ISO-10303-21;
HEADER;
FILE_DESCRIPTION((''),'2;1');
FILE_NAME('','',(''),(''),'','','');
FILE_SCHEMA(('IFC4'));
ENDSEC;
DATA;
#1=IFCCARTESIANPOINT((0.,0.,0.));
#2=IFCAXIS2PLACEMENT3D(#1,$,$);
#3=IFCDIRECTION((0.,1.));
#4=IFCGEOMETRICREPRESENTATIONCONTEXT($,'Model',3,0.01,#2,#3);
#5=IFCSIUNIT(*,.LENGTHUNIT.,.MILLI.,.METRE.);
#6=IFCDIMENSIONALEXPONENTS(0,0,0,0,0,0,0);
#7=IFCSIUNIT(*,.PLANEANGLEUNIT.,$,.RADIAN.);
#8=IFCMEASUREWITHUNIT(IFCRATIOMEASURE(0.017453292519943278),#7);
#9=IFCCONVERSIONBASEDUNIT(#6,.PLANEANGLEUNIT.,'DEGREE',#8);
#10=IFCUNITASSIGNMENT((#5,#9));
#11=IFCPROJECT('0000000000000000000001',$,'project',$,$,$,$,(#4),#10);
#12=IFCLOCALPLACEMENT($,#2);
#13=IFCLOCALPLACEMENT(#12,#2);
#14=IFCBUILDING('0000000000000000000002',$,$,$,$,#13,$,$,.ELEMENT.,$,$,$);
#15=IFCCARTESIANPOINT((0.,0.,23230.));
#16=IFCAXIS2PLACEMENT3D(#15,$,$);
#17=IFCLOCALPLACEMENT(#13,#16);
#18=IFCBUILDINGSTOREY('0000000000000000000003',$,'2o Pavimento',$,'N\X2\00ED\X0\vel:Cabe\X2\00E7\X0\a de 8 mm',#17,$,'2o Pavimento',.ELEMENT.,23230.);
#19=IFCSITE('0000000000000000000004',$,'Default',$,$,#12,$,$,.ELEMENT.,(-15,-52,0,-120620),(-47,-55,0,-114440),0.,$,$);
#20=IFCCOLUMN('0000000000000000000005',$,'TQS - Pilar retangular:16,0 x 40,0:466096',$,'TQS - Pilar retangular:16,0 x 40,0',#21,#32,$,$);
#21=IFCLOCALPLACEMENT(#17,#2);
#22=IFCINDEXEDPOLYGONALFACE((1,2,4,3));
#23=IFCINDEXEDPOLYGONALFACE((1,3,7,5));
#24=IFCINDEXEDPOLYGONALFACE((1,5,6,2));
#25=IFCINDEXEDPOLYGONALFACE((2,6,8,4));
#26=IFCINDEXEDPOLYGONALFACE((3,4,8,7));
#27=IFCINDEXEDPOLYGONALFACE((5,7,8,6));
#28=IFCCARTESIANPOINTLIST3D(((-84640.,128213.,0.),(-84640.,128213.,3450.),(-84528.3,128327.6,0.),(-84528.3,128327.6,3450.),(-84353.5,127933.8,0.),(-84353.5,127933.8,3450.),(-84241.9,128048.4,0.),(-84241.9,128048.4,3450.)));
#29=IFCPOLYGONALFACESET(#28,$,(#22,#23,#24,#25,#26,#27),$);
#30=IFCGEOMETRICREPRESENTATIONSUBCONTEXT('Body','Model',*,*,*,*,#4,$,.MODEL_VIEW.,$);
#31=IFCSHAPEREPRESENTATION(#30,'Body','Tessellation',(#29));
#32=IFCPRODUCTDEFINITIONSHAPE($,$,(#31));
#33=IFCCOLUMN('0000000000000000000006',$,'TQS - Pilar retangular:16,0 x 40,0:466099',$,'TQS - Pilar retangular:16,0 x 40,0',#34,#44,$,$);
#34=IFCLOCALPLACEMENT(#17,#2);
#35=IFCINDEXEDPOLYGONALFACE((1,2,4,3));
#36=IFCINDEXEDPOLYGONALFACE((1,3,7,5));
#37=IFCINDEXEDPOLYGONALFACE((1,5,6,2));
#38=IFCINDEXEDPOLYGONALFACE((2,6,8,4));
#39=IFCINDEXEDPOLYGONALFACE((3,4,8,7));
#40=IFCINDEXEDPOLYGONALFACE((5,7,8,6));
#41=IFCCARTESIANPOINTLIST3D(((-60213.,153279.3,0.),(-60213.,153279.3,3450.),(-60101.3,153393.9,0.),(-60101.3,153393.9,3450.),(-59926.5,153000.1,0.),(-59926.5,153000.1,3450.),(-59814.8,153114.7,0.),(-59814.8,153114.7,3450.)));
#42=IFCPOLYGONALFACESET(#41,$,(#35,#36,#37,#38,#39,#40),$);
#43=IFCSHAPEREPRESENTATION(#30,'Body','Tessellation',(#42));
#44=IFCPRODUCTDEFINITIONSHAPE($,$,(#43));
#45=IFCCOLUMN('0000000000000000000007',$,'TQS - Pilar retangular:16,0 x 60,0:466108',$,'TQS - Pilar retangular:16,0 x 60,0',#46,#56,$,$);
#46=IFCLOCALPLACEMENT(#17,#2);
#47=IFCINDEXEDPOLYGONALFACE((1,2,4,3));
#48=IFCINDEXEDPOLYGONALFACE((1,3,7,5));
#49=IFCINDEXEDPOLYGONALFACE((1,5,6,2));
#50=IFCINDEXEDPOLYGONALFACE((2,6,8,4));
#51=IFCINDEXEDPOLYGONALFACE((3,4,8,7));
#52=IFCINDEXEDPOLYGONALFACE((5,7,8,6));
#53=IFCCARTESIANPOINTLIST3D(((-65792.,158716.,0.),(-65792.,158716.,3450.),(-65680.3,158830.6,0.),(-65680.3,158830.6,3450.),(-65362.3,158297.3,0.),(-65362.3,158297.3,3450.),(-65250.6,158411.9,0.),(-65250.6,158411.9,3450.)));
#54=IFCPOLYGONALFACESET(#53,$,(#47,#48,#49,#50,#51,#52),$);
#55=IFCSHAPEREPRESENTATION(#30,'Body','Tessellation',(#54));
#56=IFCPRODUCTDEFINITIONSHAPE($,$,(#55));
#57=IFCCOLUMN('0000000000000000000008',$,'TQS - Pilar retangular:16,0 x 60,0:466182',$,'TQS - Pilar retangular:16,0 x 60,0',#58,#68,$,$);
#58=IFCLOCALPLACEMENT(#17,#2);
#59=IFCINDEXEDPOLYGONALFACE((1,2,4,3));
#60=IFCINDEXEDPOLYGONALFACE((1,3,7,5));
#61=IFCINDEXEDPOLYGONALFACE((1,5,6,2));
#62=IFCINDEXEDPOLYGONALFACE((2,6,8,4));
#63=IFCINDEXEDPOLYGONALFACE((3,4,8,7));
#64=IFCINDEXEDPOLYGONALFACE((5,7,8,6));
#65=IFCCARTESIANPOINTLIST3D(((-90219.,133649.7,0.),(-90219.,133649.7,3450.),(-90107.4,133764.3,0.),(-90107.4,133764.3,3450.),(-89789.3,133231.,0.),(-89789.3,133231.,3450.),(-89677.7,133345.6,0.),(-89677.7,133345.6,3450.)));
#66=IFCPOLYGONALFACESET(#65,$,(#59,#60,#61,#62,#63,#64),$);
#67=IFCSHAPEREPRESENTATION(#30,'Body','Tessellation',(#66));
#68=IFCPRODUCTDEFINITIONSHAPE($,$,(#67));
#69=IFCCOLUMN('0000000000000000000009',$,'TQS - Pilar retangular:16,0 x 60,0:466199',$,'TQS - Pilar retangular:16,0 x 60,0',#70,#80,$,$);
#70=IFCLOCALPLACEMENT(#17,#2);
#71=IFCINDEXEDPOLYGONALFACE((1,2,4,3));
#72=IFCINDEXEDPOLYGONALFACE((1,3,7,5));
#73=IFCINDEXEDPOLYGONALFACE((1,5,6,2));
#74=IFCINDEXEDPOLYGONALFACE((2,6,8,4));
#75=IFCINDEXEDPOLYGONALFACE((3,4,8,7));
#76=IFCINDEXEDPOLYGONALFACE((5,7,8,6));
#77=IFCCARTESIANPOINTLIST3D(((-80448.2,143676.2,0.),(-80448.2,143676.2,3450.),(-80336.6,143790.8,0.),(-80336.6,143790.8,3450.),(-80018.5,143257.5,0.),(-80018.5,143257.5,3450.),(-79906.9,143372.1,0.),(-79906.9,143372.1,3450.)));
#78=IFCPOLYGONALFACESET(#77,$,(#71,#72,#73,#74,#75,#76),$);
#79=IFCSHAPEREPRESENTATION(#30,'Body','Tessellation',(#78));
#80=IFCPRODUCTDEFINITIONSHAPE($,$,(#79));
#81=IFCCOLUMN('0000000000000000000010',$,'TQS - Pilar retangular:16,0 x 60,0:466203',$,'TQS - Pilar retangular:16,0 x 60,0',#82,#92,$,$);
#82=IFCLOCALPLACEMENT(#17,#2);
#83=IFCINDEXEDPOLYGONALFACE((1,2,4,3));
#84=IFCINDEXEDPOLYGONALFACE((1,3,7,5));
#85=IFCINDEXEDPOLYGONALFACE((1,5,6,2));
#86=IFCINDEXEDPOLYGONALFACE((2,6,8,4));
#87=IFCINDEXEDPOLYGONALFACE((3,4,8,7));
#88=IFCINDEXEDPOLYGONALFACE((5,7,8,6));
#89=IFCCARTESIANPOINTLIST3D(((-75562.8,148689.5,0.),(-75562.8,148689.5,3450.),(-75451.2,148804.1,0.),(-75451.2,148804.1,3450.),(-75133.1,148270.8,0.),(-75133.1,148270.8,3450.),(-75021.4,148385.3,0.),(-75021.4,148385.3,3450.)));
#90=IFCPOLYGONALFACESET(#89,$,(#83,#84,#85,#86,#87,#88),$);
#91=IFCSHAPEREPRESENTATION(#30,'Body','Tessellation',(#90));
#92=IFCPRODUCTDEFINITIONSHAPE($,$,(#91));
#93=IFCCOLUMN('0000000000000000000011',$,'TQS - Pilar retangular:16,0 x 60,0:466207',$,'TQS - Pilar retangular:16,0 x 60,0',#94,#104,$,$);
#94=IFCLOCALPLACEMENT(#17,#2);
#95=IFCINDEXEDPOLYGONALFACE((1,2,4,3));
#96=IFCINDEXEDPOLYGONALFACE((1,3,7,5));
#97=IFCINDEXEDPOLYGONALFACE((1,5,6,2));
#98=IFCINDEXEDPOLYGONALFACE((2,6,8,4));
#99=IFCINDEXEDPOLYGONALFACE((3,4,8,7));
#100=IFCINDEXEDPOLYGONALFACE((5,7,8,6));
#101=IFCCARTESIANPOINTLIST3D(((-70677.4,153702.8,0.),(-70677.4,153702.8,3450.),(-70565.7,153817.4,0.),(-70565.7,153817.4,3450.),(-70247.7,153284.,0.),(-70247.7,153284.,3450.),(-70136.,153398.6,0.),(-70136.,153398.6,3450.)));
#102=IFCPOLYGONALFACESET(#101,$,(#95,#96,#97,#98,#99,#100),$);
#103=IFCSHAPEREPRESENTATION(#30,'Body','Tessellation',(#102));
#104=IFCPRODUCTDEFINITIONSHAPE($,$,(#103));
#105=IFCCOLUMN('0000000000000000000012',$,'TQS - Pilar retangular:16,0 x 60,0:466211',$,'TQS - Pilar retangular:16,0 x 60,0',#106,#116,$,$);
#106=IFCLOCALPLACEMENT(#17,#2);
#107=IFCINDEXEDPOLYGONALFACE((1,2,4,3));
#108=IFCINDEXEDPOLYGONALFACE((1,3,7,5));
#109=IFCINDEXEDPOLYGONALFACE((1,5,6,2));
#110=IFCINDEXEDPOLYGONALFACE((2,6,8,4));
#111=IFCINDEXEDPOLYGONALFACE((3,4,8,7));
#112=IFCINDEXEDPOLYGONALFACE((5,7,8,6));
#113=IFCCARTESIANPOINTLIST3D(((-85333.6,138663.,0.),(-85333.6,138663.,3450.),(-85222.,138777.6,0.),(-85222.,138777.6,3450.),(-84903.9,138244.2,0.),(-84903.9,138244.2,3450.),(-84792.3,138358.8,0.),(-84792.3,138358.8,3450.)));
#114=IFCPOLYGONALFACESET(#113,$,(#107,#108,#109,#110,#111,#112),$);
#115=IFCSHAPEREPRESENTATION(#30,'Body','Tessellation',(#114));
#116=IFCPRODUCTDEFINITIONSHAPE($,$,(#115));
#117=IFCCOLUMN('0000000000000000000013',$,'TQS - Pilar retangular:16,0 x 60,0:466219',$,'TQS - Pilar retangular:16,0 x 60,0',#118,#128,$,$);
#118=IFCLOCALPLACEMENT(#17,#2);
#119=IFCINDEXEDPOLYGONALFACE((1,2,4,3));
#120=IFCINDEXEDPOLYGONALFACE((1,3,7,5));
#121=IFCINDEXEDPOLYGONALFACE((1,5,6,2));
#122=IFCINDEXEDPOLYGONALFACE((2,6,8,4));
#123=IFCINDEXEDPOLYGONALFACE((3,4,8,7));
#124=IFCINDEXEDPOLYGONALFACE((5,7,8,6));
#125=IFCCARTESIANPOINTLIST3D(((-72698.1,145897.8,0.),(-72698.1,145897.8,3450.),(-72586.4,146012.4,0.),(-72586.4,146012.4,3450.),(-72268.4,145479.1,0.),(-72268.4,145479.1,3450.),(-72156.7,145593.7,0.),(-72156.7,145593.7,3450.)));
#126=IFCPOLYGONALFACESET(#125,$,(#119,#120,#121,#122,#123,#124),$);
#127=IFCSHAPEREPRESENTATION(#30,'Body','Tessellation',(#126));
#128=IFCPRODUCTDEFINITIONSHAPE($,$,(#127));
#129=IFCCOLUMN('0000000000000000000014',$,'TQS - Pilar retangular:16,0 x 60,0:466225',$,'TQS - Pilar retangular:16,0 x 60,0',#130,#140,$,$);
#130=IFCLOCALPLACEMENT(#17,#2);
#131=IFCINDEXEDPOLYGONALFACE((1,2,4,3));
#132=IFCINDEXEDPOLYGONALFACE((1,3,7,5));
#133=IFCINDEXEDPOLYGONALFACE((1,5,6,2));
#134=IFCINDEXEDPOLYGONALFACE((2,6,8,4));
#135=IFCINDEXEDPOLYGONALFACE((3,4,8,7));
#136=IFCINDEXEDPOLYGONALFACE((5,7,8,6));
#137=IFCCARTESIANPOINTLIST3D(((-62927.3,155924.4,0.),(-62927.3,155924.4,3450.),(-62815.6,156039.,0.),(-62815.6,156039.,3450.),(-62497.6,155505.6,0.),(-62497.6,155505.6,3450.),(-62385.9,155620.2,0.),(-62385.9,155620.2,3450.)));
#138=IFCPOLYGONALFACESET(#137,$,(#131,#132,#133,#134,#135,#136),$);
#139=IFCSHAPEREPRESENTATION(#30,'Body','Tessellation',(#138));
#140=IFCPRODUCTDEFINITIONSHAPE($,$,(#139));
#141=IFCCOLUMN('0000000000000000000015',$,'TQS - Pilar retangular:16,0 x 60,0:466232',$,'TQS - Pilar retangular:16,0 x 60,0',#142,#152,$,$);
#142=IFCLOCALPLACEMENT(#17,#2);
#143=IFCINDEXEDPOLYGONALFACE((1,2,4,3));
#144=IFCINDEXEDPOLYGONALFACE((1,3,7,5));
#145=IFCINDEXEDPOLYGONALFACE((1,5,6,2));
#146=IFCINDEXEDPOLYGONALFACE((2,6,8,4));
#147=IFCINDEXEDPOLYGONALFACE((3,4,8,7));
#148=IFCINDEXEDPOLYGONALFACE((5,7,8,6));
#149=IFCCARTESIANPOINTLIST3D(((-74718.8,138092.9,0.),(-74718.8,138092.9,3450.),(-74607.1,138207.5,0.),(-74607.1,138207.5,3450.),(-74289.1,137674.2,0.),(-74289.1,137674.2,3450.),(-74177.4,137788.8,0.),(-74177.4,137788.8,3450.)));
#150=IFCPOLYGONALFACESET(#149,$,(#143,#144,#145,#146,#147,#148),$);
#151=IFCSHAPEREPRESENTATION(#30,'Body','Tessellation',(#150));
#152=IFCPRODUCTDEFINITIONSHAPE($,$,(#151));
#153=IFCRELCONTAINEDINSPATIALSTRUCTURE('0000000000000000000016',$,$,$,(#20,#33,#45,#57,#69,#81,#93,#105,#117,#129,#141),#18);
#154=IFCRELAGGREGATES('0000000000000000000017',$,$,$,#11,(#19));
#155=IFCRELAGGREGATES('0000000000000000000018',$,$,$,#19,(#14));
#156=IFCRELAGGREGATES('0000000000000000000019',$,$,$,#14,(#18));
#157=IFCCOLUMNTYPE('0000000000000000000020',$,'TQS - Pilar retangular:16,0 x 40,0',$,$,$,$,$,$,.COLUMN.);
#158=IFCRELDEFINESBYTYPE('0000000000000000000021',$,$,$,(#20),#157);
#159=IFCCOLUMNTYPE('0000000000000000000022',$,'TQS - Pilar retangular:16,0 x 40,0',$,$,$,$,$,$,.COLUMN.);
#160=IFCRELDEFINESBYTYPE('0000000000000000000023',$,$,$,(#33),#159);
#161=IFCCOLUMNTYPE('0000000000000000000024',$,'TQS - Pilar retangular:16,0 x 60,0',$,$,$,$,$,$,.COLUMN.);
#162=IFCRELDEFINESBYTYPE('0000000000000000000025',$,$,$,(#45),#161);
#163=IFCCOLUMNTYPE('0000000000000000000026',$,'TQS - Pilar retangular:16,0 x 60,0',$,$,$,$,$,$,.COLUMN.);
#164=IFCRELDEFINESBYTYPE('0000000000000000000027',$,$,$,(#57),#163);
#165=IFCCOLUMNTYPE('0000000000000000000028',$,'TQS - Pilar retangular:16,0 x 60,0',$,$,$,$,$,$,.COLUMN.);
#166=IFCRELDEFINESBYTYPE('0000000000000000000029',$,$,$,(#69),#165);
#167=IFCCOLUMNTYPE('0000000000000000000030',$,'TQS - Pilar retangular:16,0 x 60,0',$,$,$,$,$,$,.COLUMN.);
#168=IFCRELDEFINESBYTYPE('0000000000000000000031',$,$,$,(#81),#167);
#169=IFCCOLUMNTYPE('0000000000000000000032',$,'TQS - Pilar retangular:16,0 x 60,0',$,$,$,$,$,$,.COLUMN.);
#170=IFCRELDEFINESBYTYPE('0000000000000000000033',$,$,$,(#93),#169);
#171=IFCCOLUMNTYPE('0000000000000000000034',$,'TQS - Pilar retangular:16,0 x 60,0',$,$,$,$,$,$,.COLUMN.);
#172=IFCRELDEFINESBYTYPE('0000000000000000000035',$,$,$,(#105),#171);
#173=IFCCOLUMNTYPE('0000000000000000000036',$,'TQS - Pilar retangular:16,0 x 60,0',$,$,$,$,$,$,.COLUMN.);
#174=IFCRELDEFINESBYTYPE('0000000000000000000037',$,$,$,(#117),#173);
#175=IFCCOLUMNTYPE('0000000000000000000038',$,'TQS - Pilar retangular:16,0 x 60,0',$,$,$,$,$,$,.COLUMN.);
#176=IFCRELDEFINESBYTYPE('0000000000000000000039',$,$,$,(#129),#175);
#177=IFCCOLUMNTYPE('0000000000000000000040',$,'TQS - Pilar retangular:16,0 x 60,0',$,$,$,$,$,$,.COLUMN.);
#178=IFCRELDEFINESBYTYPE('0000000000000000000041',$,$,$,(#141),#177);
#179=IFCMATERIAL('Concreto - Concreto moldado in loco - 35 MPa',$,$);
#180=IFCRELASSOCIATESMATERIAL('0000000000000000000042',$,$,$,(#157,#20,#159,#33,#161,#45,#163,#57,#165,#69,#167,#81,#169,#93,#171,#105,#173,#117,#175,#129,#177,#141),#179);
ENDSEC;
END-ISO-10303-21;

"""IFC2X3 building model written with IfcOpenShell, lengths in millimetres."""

from ifc_helpers import new_model, entity, si_unit, converted_unit, direction, frame, frame_2d, origin, origin_2d_with_axis, place, context, subcontext, project, spatial, rectangle, extrude, source, transform, mapped, material, type_object, type_shapes, element, save


model = new_model("IFC2X3")

# Units and contexts
model_context = context("Model", 3, precision=0.01, world=origin(), true_north=direction((0.0, 1.0)))
body_context = subcontext(model_context, "Body", "Model", "MODEL_VIEW")
ifc_project = project(units=[si_unit("LENGTHUNIT", "METRE", prefix="MILLI"), converted_unit("PLANEANGLEUNIT", "DEGREE", entity("IfcRatioMeasure", 0.017453292519943278), si_unit("PLANEANGLEUNIT", "RADIAN"), dimensions=[0, 0, 0, 0, 0, 0, 0])], contexts=[model_context])

# Site, building, storey
site_placement = place(None, origin())
site = spatial("IfcSite", under=ifc_project, at=site_placement, Name="Default", CompositionType="ELEMENT", RefLatitude=(-15, -52, 0, -120620), RefLongitude=(-47, -55, 0, -114440), RefElevation=0.0)
building_placement = place(site_placement, origin())
building = spatial("IfcBuilding", under=site, at=building_placement, CompositionType="ELEMENT")
storey_placement = place(building_placement, frame((0.0, 0.0, 23230.0)))
storey = spatial("IfcBuildingStorey", under=building, at=storey_placement, Name="2o Pavimento", ObjectType="Nível:Cabeça de 8 mm", LongName="2o Pavimento", CompositionType="ELEMENT", Elevation=23230.0)

# Columns
ifc_material = material(Name="Concreto - Concreto moldado in loco - 35 MPa")
column_type_1 = type_object("IfcColumnType", Name="TQS - Pilar retangular:16,0 x 40,0", PredefinedType="COLUMN", material=ifc_material)
shared_shape_1 = source(origin(), body_context, "Body", "SweptSolid", [
    extrude(rectangle(XDim=400.0, YDim=160.0, at=frame_2d((0.0, 0.0), x_axis=(1.0, 0.0))), frame((-84440.9, 128130.7, 23230.0), z_axis=(0.0, 0.0, 1.0), x_axis=(-0.71618, 0.697915, 0.0)), (0.0, 0.0, 1.0), 3450.0),
])
type_shapes(column_type_1, [shared_shape_1])
column_1_placement = place(storey_placement, frame((0.0, 0.0, -23230.0)))
element("IfcColumn", 1, at=column_1_placement, inside=storey, type_object=column_type_1, material=ifc_material, Name="TQS - Pilar retangular:16,0 x 40,0:466096", ObjectType="TQS - Pilar retangular:16,0 x 40,0", context=body_context, shape_type="MappedRepresentation", body=[
    mapped(shared_shape_1, transform((0.0, 0.0, 0.0), scale=1.0)),
])
column_type_2 = type_object("IfcColumnType", Name="TQS - Pilar retangular:16,0 x 40,0", PredefinedType="COLUMN", material=ifc_material)
shared_shape_2 = source(origin(), body_context, "Body", "SweptSolid", [
    extrude(rectangle(XDim=400.0, YDim=160.0, at=frame_2d((0.0, 0.0), x_axis=(1.0, 0.0))), frame((-60013.9, 153197.0, 23230.0), z_axis=(0.0, 0.0, 1.0), x_axis=(-0.71618, 0.697915, 0.0)), (0.0, 0.0, 1.0), 3450.0),
])
type_shapes(column_type_2, [shared_shape_2])
column_2_placement = place(storey_placement, frame((0.0, 0.0, -23230.0)))
element("IfcColumn", 2, at=column_2_placement, inside=storey, type_object=column_type_2, material=ifc_material, Name="TQS - Pilar retangular:16,0 x 40,0:466099", ObjectType="TQS - Pilar retangular:16,0 x 40,0", context=body_context, shape_type="MappedRepresentation", body=[
    mapped(shared_shape_2, transform((0.0, 0.0, 0.0), scale=1.0)),
])
column_type_3 = type_object("IfcColumnType", Name="TQS - Pilar retangular:16,0 x 60,0", PredefinedType="COLUMN", material=ifc_material)
shared_shape_3 = source(origin(), body_context, "Body", "SweptSolid", [
    extrude(rectangle(XDim=600.0, YDim=160.0, at=origin_2d_with_axis()), frame((-65521.3, 158563.9, 23230.0), z_axis=(0.0, 0.0, 1.0), x_axis=(-0.71618, 0.697915, 0.0)), (0.0, 0.0, 1.0), 3450.0),
])
type_shapes(column_type_3, [shared_shape_3])
column_3_placement = place(storey_placement, frame((0.0, 0.0, -23230.0)))
element("IfcColumn", 3, at=column_3_placement, inside=storey, type_object=column_type_3, material=ifc_material, Name="TQS - Pilar retangular:16,0 x 60,0:466108", ObjectType="TQS - Pilar retangular:16,0 x 60,0", context=body_context, shape_type="MappedRepresentation", body=[
    mapped(shared_shape_3, transform((0.0, 0.0, 0.0), scale=1.0)),
])
column_type_4 = type_object("IfcColumnType", Name="TQS - Pilar retangular:16,0 x 60,0", PredefinedType="COLUMN", material=ifc_material)
shared_shape_4 = source(origin(), body_context, "Body", "SweptSolid", [
    extrude(rectangle(XDim=600.0, YDim=160.0, at=frame_2d((0.0, 0.0), x_axis=(1.0, 0.0))), frame((-89948.4, 133497.6, 23230.0), z_axis=(0.0, 0.0, 1.0), x_axis=(-0.71618, 0.697915, 0.0)), (0.0, 0.0, 1.0), 3450.0),
])
type_shapes(column_type_4, [shared_shape_4])
column_4_placement = place(storey_placement, frame((0.0, 0.0, -23230.0)))
element("IfcColumn", 4, at=column_4_placement, inside=storey, type_object=column_type_4, material=ifc_material, Name="TQS - Pilar retangular:16,0 x 60,0:466182", ObjectType="TQS - Pilar retangular:16,0 x 60,0", context=body_context, shape_type="MappedRepresentation", body=[
    mapped(shared_shape_4, transform((0.0, 0.0, 0.0), scale=1.0)),
])
column_type_5 = type_object("IfcColumnType", Name="TQS - Pilar retangular:16,0 x 60,0", PredefinedType="COLUMN", material=ifc_material)
shared_shape_5 = source(origin(), body_context, "Body", "SweptSolid", [
    extrude(rectangle(XDim=600.0, YDim=160.0, at=frame_2d((0.0, 0.0), x_axis=(1.0, 0.0))), frame((-80177.5, 143524.2, 23230.0), z_axis=(0.0, 0.0, 1.0), x_axis=(-0.71618, 0.697915, 0.0)), (0.0, 0.0, 1.0), 3450.0),
])
type_shapes(column_type_5, [shared_shape_5])
column_5_placement = place(storey_placement, frame((0.0, 0.0, -23230.0)))
element("IfcColumn", 5, at=column_5_placement, inside=storey, type_object=column_type_5, material=ifc_material, Name="TQS - Pilar retangular:16,0 x 60,0:466199", ObjectType="TQS - Pilar retangular:16,0 x 60,0", context=body_context, shape_type="MappedRepresentation", body=[
    mapped(shared_shape_5, transform((0.0, 0.0, 0.0), scale=1.0)),
])
column_type_6 = type_object("IfcColumnType", Name="TQS - Pilar retangular:16,0 x 60,0", PredefinedType="COLUMN", material=ifc_material)
shared_shape_6 = source(origin(), body_context, "Body", "SweptSolid", [
    extrude(rectangle(XDim=600.0, YDim=160.0, at=frame_2d((0.0, 0.0), x_axis=(1.0, 0.0))), frame((-75292.1, 148537.4, 23230.0), z_axis=(0.0, 0.0, 1.0), x_axis=(-0.71618, 0.697915, 0.0)), (0.0, 0.0, 1.0), 3450.0),
])
type_shapes(column_type_6, [shared_shape_6])
column_6_placement = place(storey_placement, frame((0.0, 0.0, -23230.0)))
element("IfcColumn", 6, at=column_6_placement, inside=storey, type_object=column_type_6, material=ifc_material, Name="TQS - Pilar retangular:16,0 x 60,0:466203", ObjectType="TQS - Pilar retangular:16,0 x 60,0", context=body_context, shape_type="MappedRepresentation", body=[
    mapped(shared_shape_6, transform((0.0, 0.0, 0.0), scale=1.0)),
])
column_type_7 = type_object("IfcColumnType", Name="TQS - Pilar retangular:16,0 x 60,0", PredefinedType="COLUMN", material=ifc_material)
shared_shape_7 = source(origin(), body_context, "Body", "SweptSolid", [
    extrude(rectangle(XDim=600.0, YDim=160.0, at=frame_2d((0.0, 0.0), x_axis=(1.0, 0.0))), frame((-70406.7, 153550.7, 23230.0), z_axis=(0.0, 0.0, 1.0), x_axis=(-0.71618, 0.697915, 0.0)), (0.0, 0.0, 1.0), 3450.0),
])
type_shapes(column_type_7, [shared_shape_7])
column_7_placement = place(storey_placement, frame((0.0, 0.0, -23230.0)))
element("IfcColumn", 7, at=column_7_placement, inside=storey, type_object=column_type_7, material=ifc_material, Name="TQS - Pilar retangular:16,0 x 60,0:466207", ObjectType="TQS - Pilar retangular:16,0 x 60,0", context=body_context, shape_type="MappedRepresentation", body=[
    mapped(shared_shape_7, transform((0.0, 0.0, 0.0), scale=1.0)),
])
column_type_8 = type_object("IfcColumnType", Name="TQS - Pilar retangular:16,0 x 60,0", PredefinedType="COLUMN", material=ifc_material)
shared_shape_8 = source(origin(), body_context, "Body", "SweptSolid", [
    extrude(rectangle(XDim=600.0, YDim=160.0, at=frame_2d((0.0, 0.0), x_axis=(1.0, 0.0))), frame((-85062.9, 138510.9, 23230.0), z_axis=(0.0, 0.0, 1.0), x_axis=(-0.71618, 0.697915, 0.0)), (0.0, 0.0, 1.0), 3450.0),
])
type_shapes(column_type_8, [shared_shape_8])
column_8_placement = place(storey_placement, frame((0.0, 0.0, -23230.0)))
element("IfcColumn", 8, at=column_8_placement, inside=storey, type_object=column_type_8, material=ifc_material, Name="TQS - Pilar retangular:16,0 x 60,0:466211", ObjectType="TQS - Pilar retangular:16,0 x 60,0", context=body_context, shape_type="MappedRepresentation", body=[
    mapped(shared_shape_8, transform((0.0, 0.0, 0.0), scale=1.0)),
])
column_type_9 = type_object("IfcColumnType", Name="TQS - Pilar retangular:16,0 x 60,0", PredefinedType="COLUMN", material=ifc_material)
shared_shape_9 = source(origin(), body_context, "Body", "SweptSolid", [
    extrude(rectangle(XDim=600.0, YDim=160.0, at=frame_2d((0.0, 0.0), x_axis=(1.0, 0.0))), frame((-72427.4, 145745.8, 23230.0), z_axis=(0.0, 0.0, 1.0), x_axis=(-0.71618, 0.697915, 0.0)), (0.0, 0.0, 1.0), 3450.0),
])
type_shapes(column_type_9, [shared_shape_9])
column_9_placement = place(storey_placement, frame((0.0, 0.0, -23230.0)))
element("IfcColumn", 9, at=column_9_placement, inside=storey, type_object=column_type_9, material=ifc_material, Name="TQS - Pilar retangular:16,0 x 60,0:466219", ObjectType="TQS - Pilar retangular:16,0 x 60,0", context=body_context, shape_type="MappedRepresentation", body=[
    mapped(shared_shape_9, transform((0.0, 0.0, 0.0), scale=1.0)),
])
column_type_10 = type_object("IfcColumnType", Name="TQS - Pilar retangular:16,0 x 60,0", PredefinedType="COLUMN", material=ifc_material)
shared_shape_10 = source(origin(), body_context, "Body", "SweptSolid", [
    extrude(rectangle(XDim=600.0, YDim=160.0, at=frame_2d((0.0, 0.0), x_axis=(1.0, 0.0))), frame((-62656.6, 155772.3, 23230.0), z_axis=(0.0, 0.0, 1.0), x_axis=(-0.71618, 0.697915, 0.0)), (0.0, 0.0, 1.0), 3450.0),
])
type_shapes(column_type_10, [shared_shape_10])
column_10_placement = place(storey_placement, frame((0.0, 0.0, -23230.0)))
element("IfcColumn", 10, at=column_10_placement, inside=storey, type_object=column_type_10, material=ifc_material, Name="TQS - Pilar retangular:16,0 x 60,0:466225", ObjectType="TQS - Pilar retangular:16,0 x 60,0", context=body_context, shape_type="MappedRepresentation", body=[
    mapped(shared_shape_10, transform((0.0, 0.0, 0.0), scale=1.0)),
])
column_type_11 = type_object("IfcColumnType", Name="TQS - Pilar retangular:16,0 x 60,0", PredefinedType="COLUMN", material=ifc_material)
shared_shape_11 = source(origin(), body_context, "Body", "SweptSolid", [
    extrude(rectangle(XDim=600.0, YDim=160.0, at=frame_2d((0.0, 0.0), x_axis=(1.0, 0.0))), frame((-74448.1, 137940.8, 23230.0), z_axis=(0.0, 0.0, 1.0), x_axis=(-0.71618, 0.697915, 0.0)), (0.0, 0.0, 1.0), 3450.0),
])
type_shapes(column_type_11, [shared_shape_11])
column_11_placement = place(storey_placement, frame((0.0, 0.0, -23230.0)))
element("IfcColumn", 11, at=column_11_placement, inside=storey, type_object=column_type_11, material=ifc_material, Name="TQS - Pilar retangular:16,0 x 60,0:466232", ObjectType="TQS - Pilar retangular:16,0 x 60,0", context=body_context, shape_type="MappedRepresentation", body=[
    mapped(shared_shape_11, transform((0.0, 0.0, 0.0), scale=1.0)),
])

save(model, "model.ifc")
